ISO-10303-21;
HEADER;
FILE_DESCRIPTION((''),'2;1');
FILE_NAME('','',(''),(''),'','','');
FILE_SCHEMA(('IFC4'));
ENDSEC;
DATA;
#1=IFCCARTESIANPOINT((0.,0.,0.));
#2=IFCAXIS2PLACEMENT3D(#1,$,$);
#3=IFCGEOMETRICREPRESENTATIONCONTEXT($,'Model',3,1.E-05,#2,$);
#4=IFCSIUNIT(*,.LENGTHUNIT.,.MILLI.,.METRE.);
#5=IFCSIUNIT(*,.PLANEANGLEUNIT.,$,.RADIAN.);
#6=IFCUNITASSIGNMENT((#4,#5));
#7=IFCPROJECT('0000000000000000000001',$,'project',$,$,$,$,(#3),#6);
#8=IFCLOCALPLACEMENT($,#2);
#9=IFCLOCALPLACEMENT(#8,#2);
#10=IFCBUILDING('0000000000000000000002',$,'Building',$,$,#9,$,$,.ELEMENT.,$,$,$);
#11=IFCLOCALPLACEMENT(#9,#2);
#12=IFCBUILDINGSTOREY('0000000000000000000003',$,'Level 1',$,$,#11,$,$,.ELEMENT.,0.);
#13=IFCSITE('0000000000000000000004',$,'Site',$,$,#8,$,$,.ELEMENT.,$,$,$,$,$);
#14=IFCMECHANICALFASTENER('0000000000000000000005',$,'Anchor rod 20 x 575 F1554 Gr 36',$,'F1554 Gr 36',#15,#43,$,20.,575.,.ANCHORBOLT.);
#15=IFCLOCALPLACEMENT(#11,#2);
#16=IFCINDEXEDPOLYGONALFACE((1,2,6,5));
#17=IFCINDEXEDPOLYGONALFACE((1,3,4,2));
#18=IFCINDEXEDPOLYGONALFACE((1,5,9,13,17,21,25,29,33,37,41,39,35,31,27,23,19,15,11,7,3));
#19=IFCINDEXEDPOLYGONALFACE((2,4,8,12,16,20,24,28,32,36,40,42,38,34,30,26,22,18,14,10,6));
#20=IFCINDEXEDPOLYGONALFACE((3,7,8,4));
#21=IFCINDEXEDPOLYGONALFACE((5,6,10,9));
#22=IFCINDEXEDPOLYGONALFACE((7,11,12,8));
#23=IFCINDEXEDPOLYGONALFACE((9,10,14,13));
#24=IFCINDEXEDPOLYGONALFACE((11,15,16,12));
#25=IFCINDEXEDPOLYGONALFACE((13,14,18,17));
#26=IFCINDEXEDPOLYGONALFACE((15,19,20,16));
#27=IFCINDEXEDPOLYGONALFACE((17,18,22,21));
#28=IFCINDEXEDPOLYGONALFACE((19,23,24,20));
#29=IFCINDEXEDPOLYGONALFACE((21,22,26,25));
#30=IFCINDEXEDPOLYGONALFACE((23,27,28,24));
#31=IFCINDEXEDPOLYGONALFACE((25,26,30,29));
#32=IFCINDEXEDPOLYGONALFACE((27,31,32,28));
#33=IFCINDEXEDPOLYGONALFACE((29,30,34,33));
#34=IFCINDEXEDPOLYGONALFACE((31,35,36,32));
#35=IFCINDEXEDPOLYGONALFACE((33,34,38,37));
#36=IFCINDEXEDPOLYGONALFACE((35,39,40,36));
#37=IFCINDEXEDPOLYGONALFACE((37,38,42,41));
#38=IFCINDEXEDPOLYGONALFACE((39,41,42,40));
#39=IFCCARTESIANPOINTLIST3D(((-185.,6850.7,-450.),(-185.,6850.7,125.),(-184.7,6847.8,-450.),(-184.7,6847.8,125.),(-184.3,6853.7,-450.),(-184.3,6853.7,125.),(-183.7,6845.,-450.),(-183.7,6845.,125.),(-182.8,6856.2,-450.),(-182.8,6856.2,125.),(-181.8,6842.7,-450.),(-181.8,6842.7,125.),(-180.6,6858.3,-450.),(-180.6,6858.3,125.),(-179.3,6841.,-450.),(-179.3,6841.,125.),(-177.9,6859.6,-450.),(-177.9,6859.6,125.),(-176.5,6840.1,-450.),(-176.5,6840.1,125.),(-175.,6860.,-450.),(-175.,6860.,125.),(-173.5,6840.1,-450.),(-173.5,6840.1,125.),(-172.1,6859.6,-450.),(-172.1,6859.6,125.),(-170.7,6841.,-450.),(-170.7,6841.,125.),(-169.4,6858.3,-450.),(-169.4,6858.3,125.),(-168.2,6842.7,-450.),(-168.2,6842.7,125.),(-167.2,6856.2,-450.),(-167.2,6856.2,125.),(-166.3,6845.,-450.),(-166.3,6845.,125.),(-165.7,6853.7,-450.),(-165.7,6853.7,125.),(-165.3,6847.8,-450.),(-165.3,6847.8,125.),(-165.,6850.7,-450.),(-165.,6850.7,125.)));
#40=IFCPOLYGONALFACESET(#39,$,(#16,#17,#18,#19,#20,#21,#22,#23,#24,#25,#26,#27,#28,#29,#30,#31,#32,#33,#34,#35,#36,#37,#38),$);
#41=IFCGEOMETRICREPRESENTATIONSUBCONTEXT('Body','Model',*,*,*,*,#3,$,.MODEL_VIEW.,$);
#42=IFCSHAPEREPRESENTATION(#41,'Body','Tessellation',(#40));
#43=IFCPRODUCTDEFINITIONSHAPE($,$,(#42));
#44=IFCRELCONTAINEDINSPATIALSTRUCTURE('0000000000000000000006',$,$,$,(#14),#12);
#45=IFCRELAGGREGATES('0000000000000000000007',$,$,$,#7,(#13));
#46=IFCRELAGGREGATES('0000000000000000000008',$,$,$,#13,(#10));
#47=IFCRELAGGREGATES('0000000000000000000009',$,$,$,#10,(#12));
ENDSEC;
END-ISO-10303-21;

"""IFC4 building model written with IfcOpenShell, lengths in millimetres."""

from ifc_helpers import new_model, si_unit, frame, origin, origin_2d, place, context, subcontext, project, spatial, circle, extrude, element, save


model = new_model("IFC4")

# Units and contexts
model_context = context("Model", 3, precision=1e-05, world=origin())
body_context = subcontext(model_context, "Body", "Model", "MODEL_VIEW")
ifc_project = project(units=[si_unit("LENGTHUNIT", "METRE", prefix="MILLI"), si_unit("PLANEANGLEUNIT", "RADIAN")], contexts=[model_context])

# Site, building, storey
site_placement = place(None, origin())
site = spatial("IfcSite", under=ifc_project, at=site_placement, Name="Site", CompositionType="ELEMENT")
building_placement = place(site_placement, origin())
building = spatial("IfcBuilding", under=site, at=building_placement, Name="Building", CompositionType="ELEMENT")
storey_placement = place(building_placement, origin())
storey = spatial("IfcBuildingStorey", under=building, at=storey_placement, Name="Level 1", CompositionType="ELEMENT", Elevation=0.0)

# Mechanical fastener
for number, where, z_axis, x_axis, name in (
    (1, (-175.0, 6850.0, 125.0), (0.0, 0.0, -1.0), (0.0, 1.0, 0.0), "Anchor rod 20 x 575 F1554 Gr 36"),
):
    element("IfcMechanicalFastener", number, at=place(storey_placement, frame(where, z_axis=z_axis, x_axis=x_axis)), inside=storey, Name=name, ObjectType="F1554 Gr 36", NominalDiameter=20.0, NominalLength=575.0, PredefinedType="ANCHORBOLT", context=body_context, shape_type="SweptSolid", body=[
        extrude(circle(Radius=10.0, at=origin_2d()), origin(), (0.0, 0.0, 1.0), 575.0),
    ])

save(model, "model.ifc")
